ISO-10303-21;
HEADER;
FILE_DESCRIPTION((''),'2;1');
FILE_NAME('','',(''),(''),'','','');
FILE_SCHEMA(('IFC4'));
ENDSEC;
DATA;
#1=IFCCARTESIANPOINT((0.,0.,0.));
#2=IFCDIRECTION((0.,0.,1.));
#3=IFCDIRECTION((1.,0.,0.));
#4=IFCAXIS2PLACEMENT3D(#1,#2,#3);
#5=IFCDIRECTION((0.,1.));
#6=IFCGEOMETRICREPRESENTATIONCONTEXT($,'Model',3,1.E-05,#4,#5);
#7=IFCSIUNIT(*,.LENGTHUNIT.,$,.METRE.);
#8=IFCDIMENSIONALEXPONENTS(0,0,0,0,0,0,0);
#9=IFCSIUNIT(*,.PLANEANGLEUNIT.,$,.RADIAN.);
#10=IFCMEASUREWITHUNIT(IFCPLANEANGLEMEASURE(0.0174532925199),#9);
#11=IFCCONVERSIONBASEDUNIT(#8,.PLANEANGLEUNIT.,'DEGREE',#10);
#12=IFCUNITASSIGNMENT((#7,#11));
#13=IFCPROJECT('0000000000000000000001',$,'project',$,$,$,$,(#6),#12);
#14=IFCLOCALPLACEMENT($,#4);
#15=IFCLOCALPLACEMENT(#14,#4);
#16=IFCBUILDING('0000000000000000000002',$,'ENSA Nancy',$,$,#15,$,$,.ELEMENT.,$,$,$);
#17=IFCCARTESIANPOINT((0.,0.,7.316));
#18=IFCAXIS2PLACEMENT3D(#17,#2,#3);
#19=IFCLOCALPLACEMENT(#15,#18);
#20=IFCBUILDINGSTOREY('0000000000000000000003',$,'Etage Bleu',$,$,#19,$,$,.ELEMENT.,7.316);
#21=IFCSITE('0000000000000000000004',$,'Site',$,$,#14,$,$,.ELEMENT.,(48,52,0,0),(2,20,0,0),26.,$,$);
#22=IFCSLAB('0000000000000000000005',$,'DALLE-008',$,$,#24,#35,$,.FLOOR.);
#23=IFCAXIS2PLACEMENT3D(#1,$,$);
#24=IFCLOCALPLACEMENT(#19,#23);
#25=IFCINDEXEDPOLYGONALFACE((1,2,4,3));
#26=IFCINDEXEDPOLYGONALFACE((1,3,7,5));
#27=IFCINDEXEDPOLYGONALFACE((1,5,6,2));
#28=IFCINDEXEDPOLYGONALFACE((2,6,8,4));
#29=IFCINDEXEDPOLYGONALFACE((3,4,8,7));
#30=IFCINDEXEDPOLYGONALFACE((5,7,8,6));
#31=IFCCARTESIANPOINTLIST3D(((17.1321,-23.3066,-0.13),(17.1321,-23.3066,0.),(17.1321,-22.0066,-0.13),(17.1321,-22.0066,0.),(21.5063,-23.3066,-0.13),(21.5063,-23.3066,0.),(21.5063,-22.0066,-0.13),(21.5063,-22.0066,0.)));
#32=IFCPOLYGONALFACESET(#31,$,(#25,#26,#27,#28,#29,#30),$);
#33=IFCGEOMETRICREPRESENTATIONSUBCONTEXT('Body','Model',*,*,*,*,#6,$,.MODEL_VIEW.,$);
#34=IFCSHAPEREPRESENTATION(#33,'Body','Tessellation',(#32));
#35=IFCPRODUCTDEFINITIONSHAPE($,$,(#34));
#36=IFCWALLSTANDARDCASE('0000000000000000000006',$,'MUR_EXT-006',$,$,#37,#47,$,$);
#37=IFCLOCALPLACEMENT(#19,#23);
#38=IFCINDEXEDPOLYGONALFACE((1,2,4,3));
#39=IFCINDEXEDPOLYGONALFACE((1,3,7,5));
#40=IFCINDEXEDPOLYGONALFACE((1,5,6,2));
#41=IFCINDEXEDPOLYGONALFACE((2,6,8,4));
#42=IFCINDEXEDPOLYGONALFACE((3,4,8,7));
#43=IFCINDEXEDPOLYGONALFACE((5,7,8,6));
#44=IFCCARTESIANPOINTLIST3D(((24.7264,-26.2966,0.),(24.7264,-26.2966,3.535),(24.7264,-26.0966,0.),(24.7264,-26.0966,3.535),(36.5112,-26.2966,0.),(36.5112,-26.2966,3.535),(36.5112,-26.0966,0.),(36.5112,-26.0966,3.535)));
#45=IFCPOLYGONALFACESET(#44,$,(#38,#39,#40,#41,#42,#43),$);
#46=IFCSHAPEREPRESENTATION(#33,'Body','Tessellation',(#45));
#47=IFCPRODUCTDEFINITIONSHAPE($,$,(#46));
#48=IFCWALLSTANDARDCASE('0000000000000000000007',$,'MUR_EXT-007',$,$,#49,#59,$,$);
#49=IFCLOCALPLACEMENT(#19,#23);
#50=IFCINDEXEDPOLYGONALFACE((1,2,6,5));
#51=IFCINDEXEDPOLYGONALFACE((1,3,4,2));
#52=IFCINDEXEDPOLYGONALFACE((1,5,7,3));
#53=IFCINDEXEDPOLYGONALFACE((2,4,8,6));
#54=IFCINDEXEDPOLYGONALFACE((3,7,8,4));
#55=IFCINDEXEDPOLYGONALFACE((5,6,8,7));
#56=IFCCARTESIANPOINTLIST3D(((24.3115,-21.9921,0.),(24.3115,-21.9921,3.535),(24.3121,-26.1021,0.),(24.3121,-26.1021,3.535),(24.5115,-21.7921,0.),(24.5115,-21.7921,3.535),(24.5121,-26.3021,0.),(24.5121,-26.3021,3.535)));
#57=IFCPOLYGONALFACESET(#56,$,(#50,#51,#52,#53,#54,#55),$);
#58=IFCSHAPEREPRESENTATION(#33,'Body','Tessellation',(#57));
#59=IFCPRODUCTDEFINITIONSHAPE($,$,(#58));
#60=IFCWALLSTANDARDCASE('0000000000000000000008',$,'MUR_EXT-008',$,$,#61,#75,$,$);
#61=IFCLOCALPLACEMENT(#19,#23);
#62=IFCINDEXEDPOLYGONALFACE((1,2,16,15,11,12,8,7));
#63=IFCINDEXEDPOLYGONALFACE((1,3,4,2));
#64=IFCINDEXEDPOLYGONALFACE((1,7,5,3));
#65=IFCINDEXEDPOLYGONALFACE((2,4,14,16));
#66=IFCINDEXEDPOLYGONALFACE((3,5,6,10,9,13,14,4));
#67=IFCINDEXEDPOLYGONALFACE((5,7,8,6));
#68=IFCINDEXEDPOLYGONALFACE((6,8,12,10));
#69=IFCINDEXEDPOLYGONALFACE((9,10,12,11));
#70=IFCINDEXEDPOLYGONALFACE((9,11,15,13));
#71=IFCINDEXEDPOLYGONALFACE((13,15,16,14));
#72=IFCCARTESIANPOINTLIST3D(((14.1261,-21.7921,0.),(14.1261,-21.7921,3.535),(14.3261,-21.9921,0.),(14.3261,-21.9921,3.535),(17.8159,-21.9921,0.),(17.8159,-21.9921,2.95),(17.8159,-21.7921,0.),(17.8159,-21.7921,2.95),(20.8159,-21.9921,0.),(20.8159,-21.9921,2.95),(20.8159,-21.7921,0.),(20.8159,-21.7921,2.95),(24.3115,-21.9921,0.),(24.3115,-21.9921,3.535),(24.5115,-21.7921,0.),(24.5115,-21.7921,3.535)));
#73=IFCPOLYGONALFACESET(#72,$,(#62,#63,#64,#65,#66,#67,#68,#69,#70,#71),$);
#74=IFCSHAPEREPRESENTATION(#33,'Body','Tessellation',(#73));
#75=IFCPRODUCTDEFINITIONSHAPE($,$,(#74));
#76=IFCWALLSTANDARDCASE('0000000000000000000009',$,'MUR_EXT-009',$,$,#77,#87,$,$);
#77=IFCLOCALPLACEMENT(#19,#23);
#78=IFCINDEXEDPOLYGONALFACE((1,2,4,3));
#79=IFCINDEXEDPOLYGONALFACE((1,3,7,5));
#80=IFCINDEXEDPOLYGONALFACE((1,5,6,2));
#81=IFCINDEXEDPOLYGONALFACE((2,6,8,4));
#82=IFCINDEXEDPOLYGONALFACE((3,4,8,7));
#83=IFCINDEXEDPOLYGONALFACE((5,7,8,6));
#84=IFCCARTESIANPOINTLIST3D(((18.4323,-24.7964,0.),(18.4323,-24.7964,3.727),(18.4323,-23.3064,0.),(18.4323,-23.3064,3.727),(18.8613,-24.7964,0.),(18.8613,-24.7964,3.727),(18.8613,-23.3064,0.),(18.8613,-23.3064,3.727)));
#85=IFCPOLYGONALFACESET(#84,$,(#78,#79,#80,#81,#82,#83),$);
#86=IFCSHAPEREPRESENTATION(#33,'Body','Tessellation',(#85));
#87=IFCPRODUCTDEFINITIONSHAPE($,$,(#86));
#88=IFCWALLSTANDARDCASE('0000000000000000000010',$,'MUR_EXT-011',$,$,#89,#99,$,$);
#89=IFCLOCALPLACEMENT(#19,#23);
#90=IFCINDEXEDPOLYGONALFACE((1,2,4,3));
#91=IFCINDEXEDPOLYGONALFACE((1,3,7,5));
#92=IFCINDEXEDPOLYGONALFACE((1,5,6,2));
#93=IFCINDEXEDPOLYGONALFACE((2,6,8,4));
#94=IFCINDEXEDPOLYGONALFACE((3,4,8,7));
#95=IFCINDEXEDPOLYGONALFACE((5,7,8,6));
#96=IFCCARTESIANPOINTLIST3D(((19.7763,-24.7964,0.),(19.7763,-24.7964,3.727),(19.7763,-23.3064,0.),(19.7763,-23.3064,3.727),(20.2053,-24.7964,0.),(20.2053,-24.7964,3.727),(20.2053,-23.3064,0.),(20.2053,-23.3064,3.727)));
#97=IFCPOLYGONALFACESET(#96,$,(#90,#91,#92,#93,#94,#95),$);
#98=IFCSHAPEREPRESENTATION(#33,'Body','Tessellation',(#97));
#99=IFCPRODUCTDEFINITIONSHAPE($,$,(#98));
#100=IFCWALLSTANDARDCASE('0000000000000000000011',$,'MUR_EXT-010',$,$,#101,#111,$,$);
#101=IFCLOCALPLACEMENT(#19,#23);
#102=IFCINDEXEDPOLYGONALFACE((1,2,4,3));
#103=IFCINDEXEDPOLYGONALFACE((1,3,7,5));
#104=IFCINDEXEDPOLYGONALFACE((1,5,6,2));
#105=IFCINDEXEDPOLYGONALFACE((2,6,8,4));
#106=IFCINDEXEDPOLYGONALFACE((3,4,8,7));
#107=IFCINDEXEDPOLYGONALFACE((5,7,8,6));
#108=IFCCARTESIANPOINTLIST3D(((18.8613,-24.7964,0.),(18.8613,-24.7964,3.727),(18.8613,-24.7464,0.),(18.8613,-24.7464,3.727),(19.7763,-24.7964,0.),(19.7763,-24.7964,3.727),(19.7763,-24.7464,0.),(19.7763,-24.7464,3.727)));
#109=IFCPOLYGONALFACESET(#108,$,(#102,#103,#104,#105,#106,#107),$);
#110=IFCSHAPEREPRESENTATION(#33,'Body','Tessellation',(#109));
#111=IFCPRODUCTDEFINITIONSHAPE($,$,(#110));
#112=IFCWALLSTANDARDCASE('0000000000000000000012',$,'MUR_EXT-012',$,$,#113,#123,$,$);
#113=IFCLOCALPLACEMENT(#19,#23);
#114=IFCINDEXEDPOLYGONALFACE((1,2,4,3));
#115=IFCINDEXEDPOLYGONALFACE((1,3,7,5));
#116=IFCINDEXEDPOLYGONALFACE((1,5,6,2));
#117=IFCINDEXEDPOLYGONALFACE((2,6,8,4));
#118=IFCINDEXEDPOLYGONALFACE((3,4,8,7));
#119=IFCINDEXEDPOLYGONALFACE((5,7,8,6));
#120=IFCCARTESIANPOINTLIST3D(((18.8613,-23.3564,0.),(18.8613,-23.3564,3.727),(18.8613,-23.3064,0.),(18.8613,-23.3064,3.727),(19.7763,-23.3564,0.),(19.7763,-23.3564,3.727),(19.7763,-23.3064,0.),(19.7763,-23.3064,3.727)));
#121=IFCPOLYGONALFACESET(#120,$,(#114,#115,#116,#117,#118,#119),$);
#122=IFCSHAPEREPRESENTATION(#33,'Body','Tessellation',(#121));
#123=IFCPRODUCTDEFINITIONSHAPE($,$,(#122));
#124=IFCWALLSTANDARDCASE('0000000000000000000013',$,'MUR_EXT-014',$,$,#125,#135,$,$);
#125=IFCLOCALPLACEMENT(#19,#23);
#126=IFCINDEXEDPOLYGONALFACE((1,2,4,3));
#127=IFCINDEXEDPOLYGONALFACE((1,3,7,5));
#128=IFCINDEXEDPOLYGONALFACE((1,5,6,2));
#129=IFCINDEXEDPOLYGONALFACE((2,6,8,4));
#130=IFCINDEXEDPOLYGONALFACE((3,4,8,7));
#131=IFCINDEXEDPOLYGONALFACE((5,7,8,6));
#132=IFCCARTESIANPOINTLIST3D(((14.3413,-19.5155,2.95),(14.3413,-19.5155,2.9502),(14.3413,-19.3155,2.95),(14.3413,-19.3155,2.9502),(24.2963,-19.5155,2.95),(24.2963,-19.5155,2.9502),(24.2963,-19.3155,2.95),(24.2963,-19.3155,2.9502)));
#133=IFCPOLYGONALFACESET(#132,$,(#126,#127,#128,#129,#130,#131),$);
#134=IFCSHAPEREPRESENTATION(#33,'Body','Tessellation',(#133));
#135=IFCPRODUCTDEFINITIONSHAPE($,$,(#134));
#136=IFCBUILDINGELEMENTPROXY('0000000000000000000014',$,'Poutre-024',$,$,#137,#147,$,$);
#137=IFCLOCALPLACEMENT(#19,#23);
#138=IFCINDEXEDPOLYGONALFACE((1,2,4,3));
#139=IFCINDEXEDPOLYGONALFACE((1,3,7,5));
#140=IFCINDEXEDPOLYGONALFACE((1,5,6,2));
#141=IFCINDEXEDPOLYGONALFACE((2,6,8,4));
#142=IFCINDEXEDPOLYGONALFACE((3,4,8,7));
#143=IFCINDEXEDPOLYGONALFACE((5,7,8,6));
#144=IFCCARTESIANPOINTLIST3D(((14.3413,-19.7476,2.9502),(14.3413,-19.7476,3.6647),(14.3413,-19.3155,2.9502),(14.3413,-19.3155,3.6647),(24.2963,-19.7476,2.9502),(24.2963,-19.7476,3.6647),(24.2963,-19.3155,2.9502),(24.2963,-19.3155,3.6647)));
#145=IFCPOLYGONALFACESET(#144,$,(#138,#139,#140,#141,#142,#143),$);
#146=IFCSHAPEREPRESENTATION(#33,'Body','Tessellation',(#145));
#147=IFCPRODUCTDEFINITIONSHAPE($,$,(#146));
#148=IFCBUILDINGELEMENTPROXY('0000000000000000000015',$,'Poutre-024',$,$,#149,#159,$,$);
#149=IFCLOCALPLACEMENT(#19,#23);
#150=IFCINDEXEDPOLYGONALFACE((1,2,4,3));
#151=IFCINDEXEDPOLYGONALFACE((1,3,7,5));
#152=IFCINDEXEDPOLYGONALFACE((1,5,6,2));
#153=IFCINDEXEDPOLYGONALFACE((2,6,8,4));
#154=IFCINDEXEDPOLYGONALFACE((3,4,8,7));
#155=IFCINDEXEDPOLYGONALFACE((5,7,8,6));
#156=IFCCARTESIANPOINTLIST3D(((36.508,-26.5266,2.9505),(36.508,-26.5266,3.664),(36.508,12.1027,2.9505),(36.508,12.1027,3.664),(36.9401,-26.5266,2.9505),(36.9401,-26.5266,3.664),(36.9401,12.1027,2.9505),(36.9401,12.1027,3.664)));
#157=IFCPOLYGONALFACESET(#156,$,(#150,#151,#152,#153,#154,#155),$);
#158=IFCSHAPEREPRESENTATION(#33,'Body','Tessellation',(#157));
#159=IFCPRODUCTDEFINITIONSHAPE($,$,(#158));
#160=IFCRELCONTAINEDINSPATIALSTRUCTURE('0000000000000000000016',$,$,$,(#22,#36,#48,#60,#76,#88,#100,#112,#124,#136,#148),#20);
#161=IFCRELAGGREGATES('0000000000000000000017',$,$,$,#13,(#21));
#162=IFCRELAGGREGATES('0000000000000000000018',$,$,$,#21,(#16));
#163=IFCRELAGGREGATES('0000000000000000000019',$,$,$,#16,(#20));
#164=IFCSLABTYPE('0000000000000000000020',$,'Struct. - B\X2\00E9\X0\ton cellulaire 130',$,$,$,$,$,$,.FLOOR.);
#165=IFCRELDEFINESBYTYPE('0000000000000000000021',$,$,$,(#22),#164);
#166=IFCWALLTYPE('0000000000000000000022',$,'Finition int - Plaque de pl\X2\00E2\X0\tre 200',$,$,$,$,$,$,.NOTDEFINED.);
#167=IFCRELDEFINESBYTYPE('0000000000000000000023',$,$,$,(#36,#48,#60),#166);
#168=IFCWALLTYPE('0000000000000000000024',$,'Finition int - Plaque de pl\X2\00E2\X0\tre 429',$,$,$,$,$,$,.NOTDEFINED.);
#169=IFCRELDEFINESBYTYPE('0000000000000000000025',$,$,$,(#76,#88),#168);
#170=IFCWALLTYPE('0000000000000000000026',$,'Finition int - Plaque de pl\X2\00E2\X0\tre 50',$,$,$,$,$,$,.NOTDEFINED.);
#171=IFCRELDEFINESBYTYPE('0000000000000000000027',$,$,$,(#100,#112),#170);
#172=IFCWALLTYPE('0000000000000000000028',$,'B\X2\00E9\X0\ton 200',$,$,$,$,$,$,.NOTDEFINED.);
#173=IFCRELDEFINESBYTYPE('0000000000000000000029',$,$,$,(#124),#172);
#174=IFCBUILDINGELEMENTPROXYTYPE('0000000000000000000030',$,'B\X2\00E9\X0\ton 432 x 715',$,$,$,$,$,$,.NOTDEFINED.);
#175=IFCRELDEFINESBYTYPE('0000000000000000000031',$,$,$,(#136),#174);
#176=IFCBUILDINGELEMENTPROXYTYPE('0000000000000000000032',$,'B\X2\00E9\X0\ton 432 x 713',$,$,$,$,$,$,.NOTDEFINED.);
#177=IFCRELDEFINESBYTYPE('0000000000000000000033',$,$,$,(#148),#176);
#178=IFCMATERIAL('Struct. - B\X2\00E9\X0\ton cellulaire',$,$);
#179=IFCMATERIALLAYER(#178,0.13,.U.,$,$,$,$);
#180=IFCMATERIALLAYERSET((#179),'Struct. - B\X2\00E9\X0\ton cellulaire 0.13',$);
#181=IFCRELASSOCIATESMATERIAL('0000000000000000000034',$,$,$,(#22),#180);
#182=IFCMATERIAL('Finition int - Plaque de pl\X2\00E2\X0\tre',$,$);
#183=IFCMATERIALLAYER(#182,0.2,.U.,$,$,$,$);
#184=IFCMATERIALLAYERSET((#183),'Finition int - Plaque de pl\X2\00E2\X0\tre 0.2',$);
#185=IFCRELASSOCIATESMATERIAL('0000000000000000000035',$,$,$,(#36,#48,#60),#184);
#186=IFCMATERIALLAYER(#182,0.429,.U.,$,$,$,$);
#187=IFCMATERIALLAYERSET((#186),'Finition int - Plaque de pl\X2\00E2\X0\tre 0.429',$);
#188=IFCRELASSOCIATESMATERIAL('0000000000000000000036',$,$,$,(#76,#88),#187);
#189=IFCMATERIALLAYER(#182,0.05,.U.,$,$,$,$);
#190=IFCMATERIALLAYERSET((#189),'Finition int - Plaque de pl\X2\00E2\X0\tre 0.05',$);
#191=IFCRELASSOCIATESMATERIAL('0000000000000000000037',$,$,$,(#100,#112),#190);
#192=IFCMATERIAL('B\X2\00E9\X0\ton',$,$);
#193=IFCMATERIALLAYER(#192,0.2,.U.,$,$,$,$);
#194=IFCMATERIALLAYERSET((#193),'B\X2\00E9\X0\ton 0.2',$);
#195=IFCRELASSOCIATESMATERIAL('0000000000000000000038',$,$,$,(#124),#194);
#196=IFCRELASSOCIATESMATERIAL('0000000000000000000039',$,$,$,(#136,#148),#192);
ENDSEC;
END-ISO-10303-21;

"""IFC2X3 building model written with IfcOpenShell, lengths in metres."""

from ifc_helpers import new_model, entity, si_unit, converted_unit, direction, frame, frame_2d, origin_with_axes, origin_2d_with_axis, place, context, subcontext, project, spatial, polyline, rectangle, outline, extrude, material, layer, layer_set, layer_usage, type_object, element, save


model = new_model("IFC2X3")

# Units and contexts
model_context = context("Model", 3, precision=1e-05, world=origin_with_axes(), true_north=direction((0.0, 1.0)))
body_context = subcontext(model_context, "Body", "Model", "MODEL_VIEW")
ifc_project = project(units=[si_unit("LENGTHUNIT", "METRE"), converted_unit("PLANEANGLEUNIT", "DEGREE", entity("IfcPlaneAngleMeasure", 0.0174532925199), si_unit("PLANEANGLEUNIT", "RADIAN"), dimensions=[0, 0, 0, 0, 0, 0, 0])], contexts=[model_context])

# Site, building, storey
site_placement = place(None, origin_with_axes())
site = spatial("IfcSite", under=ifc_project, at=site_placement, Name="Site", CompositionType="ELEMENT", RefLatitude=(48, 52, 0, 0), RefLongitude=(2, 20, 0, 0), RefElevation=26.0)
building_placement = place(site_placement, origin_with_axes())
building = spatial("IfcBuilding", under=site, at=building_placement, Name="ENSA Nancy", CompositionType="ELEMENT")
storey_placement = place(building_placement, frame((0.0, 0.0, 7.316), z_axis=(0.0, 0.0, 1.0), x_axis=(1.0, 0.0, 0.0)))
storey = spatial("IfcBuildingStorey", under=building, at=storey_placement, Name="Etage Bleu", CompositionType="ELEMENT", Elevation=7.316)

# Slab
ifc_material_1 = material(Name="Struct. - Béton cellulaire")
ifc_layer_1 = layer(ifc_material_1, 0.13, ventilated="UNKNOWN")
ifc_layer_set_1 = layer_set([ifc_layer_1], Name="Struct. - Béton cellulaire 0.13")
ifc_layer_usage_1 = layer_usage(ifc_layer_set_1, "AXIS3", "NEGATIVE", 0.13)
slab_type = type_object("IfcSlabType", Name="Struct. - Béton cellulaire 130", PredefinedType="FLOOR")
slab_placement = place(storey_placement, frame((17.1321, -23.3066, 0.0), z_axis=(0.0, 0.0, 1.0), x_axis=(1.0, 0.0, 0.0)))
element("IfcSlab", 1, at=slab_placement, inside=storey, type_object=slab_type, material=ifc_layer_usage_1, Name="DALLE-008", PredefinedType="FLOOR", context=body_context, shape_type="SweptSolid", body=[
    extrude(outline(polyline([(0.0, 0.0), (4.3743, 0.0), (4.3743, 1.3), (0.0, 1.3), (0.0, 0.0)])), frame((0.0, 0.0, -0.13), z_axis=(0.0, 0.0, 1.0), x_axis=(1.0, 0.0, 0.0)), (0.0, 0.0, 1.0), 0.13),
])

# Walls
ifc_material_2 = material(Name="Finition int - Plaque de plâtre")
ifc_layer_2 = layer(ifc_material_2, 0.2, ventilated="UNKNOWN")
ifc_layer_set_2 = layer_set([ifc_layer_2], Name="Finition int - Plaque de plâtre 0.2")
ifc_layer_usage_2 = layer_usage(ifc_layer_set_2, "AXIS2", "NEGATIVE", 0.0)
wall_type_1 = type_object("IfcWallType", Name="Finition int - Plaque de plâtre 200", PredefinedType="NOTDEFINED")
wall_1_placement = place(storey_placement, frame((36.5112, -26.2966, 0.0), z_axis=(0.0, 0.0, 1.0), x_axis=(-1.0, 0.0, 0.0)))
element("IfcWallStandardCase", 2, at=wall_1_placement, inside=storey, type_object=wall_type_1, material=ifc_layer_usage_2, Name="MUR_EXT-006", context=body_context, shape_type="SweptSolid", body=[
    extrude(outline(polyline([(0.0, -0.2), (11.7849, -0.2), (11.7849, 0.0), (0.0, 0.0), (0.0, -0.2)])), origin_with_axes(), (0.0, 0.0, 1.0), 3.535),
])
ifc_layer_usage_3 = layer_usage(ifc_layer_set_2, "AXIS2", "POSITIVE", 0.0)
wall_2_placement = place(storey_placement, frame((24.5121, -26.3021, 0.0), z_axis=(0.0, 0.0, 1.0), x_axis=(-0.00015, 1.0, 0.0)))
element("IfcWallStandardCase", 3, at=wall_2_placement, inside=storey, type_object=wall_type_1, material=ifc_layer_usage_3, Name="MUR_EXT-007", context=body_context, shape_type="SweptSolid", body=[
    extrude(outline(polyline([(0.0, 0.0), (4.51, 0.0), (4.31, 0.2), (0.2, 0.2), (0.0, 0.0)])), origin_with_axes(), (0.0, 0.0, 1.0), 3.535),
])

# Wall, opening
ifc_layer_usage_4 = layer_usage(ifc_layer_set_2, "AXIS2", "POSITIVE", 0.0)
wall_3_placement = place(storey_placement, frame((24.5115, -21.7921, 0.0), z_axis=(0.0, 0.0, 1.0), x_axis=(-1.0, -0.000003, 0.0)))
wall_3 = element("IfcWallStandardCase", 4, at=wall_3_placement, inside=storey, type_object=wall_type_1, material=ifc_layer_usage_4, Name="MUR_EXT-008", context=body_context, shape_type="SweptSolid", body=[
    extrude(outline(polyline([(0.0, 0.0), (10.3854, 0.0), (10.1854, 0.2), (0.2, 0.2), (0.0, 0.0)])), origin_with_axes(), (0.0, 0.0, 1.0), 3.535),
])
opening_1_placement = place(wall_3_placement, frame((5.1955, 0.0, 0.0), z_axis=(0.0, 0.0, 1.0), x_axis=(1.0, 0.0, 0.0)))
element("IfcOpeningElement", 5, at=opening_1_placement, cuts=wall_3, context=body_context, shape_type="SweptSolid", body=[
    extrude(rectangle(XDim=3.0, YDim=2.95, at=origin_2d_with_axis()), frame((0.0, 0.2, 1.475), z_axis=(0.0, -1.0, 0.0), x_axis=(1.0, 0.0, 0.0)), (0.0, 0.0, 1.0), 0.6),
])

# Walls
ifc_layer_3 = layer(ifc_material_2, 0.429, ventilated="UNKNOWN")
ifc_layer_set_3 = layer_set([ifc_layer_3], Name="Finition int - Plaque de plâtre 0.429")
ifc_layer_usage_5 = layer_usage(ifc_layer_set_3, "AXIS2", "POSITIVE", -0.429)
wall_type_2 = type_object("IfcWallType", Name="Finition int - Plaque de plâtre 429", PredefinedType="NOTDEFINED")
wall_4_placement = place(storey_placement, frame((18.8613, -23.3064, 0.0), z_axis=(0.0, 0.0, 1.0), x_axis=(0.0, -1.0, 0.0)))
element("IfcWallStandardCase", 6, at=wall_4_placement, inside=storey, type_object=wall_type_2, material=ifc_layer_usage_5, Name="MUR_EXT-009", context=body_context, shape_type="SweptSolid", body=[
    extrude(outline(polyline([(0.0, -0.429), (1.49, -0.429), (1.49, 0.0), (0.0, 0.0), (0.0, -0.429)])), origin_with_axes(), (0.0, 0.0, 1.0), 3.727),
])
ifc_layer_usage_6 = layer_usage(ifc_layer_set_3, "AXIS2", "POSITIVE", -0.429)
wall_5_placement = place(storey_placement, frame((19.7763, -24.7964, 0.0), z_axis=(0.0, 0.0, 1.0), x_axis=(0.0, 1.0, 0.0)))
element("IfcWallStandardCase", 7, at=wall_5_placement, inside=storey, type_object=wall_type_2, material=ifc_layer_usage_6, Name="MUR_EXT-011", context=body_context, shape_type="SweptSolid", body=[
    extrude(outline(polyline([(0.0, -0.429), (1.49, -0.429), (1.49, 0.0), (0.0, 0.0), (0.0, -0.429)])), origin_with_axes(), (0.0, 0.0, 1.0), 3.727),
])
ifc_layer_4 = layer(ifc_material_2, 0.05, ventilated="UNKNOWN")
ifc_layer_set_4 = layer_set([ifc_layer_4], Name="Finition int - Plaque de plâtre 0.05")
ifc_layer_usage_7 = layer_usage(ifc_layer_set_4, "AXIS2", "POSITIVE", -0.05)
wall_type_3 = type_object("IfcWallType", Name="Finition int - Plaque de plâtre 50", PredefinedType="NOTDEFINED")
wall_6_placement = place(storey_placement, frame((18.8613, -24.7464, 0.0), z_axis=(0.0, 0.0, 1.0), x_axis=(1.0, 0.0, 0.0)))
element("IfcWallStandardCase", 8, at=wall_6_placement, inside=storey, type_object=wall_type_3, material=ifc_layer_usage_7, Name="MUR_EXT-010", context=body_context, shape_type="SweptSolid", body=[
    extrude(outline(polyline([(0.0, -0.05), (0.915, -0.05), (0.915, 0.0), (0.0, 0.0), (0.0, -0.05)])), origin_with_axes(), (0.0, 0.0, 1.0), 3.727),
])
ifc_layer_usage_8 = layer_usage(ifc_layer_set_4, "AXIS2", "POSITIVE", -0.05)
wall_7_placement = place(storey_placement, frame((19.7763, -23.3564, 0.0), z_axis=(0.0, 0.0, 1.0), x_axis=(-1.0, 0.0, 0.0)))
element("IfcWallStandardCase", 9, at=wall_7_placement, inside=storey, type_object=wall_type_3, material=ifc_layer_usage_8, Name="MUR_EXT-012", context=body_context, shape_type="SweptSolid", body=[
    extrude(outline(polyline([(0.0, -0.05), (0.915, -0.05), (0.915, 0.0), (0.0, 0.0), (0.0, -0.05)])), origin_with_axes(), (0.0, 0.0, 1.0), 3.727),
])

# Wall, opening
ifc_material_3 = material(Name="Béton")
ifc_layer_5 = layer(ifc_material_3, 0.2, ventilated="UNKNOWN")
ifc_layer_set_5 = layer_set([ifc_layer_5], Name="Béton 0.2")
ifc_layer_usage_9 = layer_usage(ifc_layer_set_5, "AXIS2", "POSITIVE", -0.2)
wall_type_4 = type_object("IfcWallType", Name="Béton 200", PredefinedType="NOTDEFINED")
wall_8_placement = place(storey_placement, frame((14.3413, -19.3155, 0.0), z_axis=(0.0, 0.0, 1.0), x_axis=(1.0, 0.0, 0.0)))
wall_8 = element("IfcWallStandardCase", 10, at=wall_8_placement, inside=storey, type_object=wall_type_4, material=ifc_layer_usage_9, Name="MUR_EXT-014", context=body_context, shape_type="SweptSolid", body=[
    extrude(outline(polyline([(0.0, -0.2), (9.955, -0.2), (9.955, 0.0), (0.0, 0.0), (0.0, -0.2)])), origin_with_axes(), (0.0, 0.0, 1.0), 2.9502),
])
opening_2_placement = place(wall_8_placement, frame((4.9775, 0.0, 0.0), z_axis=(0.0, 0.0, 1.0), x_axis=(1.0, 0.0, 0.0)))
element("IfcOpeningElement", 11, at=opening_2_placement, cuts=wall_8, context=body_context, shape_type="SweptSolid", body=[
    extrude(rectangle(XDim=9.955, YDim=2.95, at=origin_2d_with_axis()), frame((0.0, -0.2, 1.475), z_axis=(0.0, -1.0, 0.0), x_axis=(1.0, 0.0, 0.0)), (0.0, 0.0, -1.0), 0.6),
])

# Building element proxies
building_element_proxy_type_1 = type_object("IfcBuildingElementProxyType", Name="Béton 432 x 715", PredefinedType="NOTDEFINED")
proxy_1_placement = place(storey_placement, frame((24.2963, -19.5316, 3.6647), z_axis=(0.0, 0.0, 1.0), x_axis=(0.0, 1.0, 0.0)))
element("IfcBuildingElementProxy", 12, at=proxy_1_placement, inside=storey, type_object=building_element_proxy_type_1, material=ifc_material_3, Name="Poutre-024", context=body_context, shape_type="SweptSolid", body=[
    extrude(rectangle(XDim=0.7145, YDim=0.4321, at=frame_2d((-0.3573, 0.0), x_axis=(1.0, 0.0))), frame((0.0, 0.0, 0.0), z_axis=(0.0, 1.0, 0.0), x_axis=(0.0, 0.0, 1.0)), (0.0, 0.0, 1.0), 9.955),
])
building_element_proxy_type_2 = type_object("IfcBuildingElementProxyType", Name="Béton 432 x 713", PredefinedType="NOTDEFINED")
proxy_2_placement = place(storey_placement, frame((36.724, -26.5266, 3.664), z_axis=(0.0, 0.0, 1.0), x_axis=(1.0, 0.0, 0.0)))
element("IfcBuildingElementProxy", 13, at=proxy_2_placement, inside=storey, type_object=building_element_proxy_type_2, material=ifc_material_3, Name="Poutre-024", context=body_context, shape_type="SweptSolid", body=[
    extrude(rectangle(XDim=0.7135, YDim=0.4321, at=frame_2d((-0.3567, 0.0), x_axis=(1.0, 0.0))), frame((0.0, 0.0, 0.0), z_axis=(0.0, 1.0, 0.0), x_axis=(0.0, 0.0, 1.0)), (0.0, 0.0, 1.0), 38.6293),
])

save(model, "model.ifc")
